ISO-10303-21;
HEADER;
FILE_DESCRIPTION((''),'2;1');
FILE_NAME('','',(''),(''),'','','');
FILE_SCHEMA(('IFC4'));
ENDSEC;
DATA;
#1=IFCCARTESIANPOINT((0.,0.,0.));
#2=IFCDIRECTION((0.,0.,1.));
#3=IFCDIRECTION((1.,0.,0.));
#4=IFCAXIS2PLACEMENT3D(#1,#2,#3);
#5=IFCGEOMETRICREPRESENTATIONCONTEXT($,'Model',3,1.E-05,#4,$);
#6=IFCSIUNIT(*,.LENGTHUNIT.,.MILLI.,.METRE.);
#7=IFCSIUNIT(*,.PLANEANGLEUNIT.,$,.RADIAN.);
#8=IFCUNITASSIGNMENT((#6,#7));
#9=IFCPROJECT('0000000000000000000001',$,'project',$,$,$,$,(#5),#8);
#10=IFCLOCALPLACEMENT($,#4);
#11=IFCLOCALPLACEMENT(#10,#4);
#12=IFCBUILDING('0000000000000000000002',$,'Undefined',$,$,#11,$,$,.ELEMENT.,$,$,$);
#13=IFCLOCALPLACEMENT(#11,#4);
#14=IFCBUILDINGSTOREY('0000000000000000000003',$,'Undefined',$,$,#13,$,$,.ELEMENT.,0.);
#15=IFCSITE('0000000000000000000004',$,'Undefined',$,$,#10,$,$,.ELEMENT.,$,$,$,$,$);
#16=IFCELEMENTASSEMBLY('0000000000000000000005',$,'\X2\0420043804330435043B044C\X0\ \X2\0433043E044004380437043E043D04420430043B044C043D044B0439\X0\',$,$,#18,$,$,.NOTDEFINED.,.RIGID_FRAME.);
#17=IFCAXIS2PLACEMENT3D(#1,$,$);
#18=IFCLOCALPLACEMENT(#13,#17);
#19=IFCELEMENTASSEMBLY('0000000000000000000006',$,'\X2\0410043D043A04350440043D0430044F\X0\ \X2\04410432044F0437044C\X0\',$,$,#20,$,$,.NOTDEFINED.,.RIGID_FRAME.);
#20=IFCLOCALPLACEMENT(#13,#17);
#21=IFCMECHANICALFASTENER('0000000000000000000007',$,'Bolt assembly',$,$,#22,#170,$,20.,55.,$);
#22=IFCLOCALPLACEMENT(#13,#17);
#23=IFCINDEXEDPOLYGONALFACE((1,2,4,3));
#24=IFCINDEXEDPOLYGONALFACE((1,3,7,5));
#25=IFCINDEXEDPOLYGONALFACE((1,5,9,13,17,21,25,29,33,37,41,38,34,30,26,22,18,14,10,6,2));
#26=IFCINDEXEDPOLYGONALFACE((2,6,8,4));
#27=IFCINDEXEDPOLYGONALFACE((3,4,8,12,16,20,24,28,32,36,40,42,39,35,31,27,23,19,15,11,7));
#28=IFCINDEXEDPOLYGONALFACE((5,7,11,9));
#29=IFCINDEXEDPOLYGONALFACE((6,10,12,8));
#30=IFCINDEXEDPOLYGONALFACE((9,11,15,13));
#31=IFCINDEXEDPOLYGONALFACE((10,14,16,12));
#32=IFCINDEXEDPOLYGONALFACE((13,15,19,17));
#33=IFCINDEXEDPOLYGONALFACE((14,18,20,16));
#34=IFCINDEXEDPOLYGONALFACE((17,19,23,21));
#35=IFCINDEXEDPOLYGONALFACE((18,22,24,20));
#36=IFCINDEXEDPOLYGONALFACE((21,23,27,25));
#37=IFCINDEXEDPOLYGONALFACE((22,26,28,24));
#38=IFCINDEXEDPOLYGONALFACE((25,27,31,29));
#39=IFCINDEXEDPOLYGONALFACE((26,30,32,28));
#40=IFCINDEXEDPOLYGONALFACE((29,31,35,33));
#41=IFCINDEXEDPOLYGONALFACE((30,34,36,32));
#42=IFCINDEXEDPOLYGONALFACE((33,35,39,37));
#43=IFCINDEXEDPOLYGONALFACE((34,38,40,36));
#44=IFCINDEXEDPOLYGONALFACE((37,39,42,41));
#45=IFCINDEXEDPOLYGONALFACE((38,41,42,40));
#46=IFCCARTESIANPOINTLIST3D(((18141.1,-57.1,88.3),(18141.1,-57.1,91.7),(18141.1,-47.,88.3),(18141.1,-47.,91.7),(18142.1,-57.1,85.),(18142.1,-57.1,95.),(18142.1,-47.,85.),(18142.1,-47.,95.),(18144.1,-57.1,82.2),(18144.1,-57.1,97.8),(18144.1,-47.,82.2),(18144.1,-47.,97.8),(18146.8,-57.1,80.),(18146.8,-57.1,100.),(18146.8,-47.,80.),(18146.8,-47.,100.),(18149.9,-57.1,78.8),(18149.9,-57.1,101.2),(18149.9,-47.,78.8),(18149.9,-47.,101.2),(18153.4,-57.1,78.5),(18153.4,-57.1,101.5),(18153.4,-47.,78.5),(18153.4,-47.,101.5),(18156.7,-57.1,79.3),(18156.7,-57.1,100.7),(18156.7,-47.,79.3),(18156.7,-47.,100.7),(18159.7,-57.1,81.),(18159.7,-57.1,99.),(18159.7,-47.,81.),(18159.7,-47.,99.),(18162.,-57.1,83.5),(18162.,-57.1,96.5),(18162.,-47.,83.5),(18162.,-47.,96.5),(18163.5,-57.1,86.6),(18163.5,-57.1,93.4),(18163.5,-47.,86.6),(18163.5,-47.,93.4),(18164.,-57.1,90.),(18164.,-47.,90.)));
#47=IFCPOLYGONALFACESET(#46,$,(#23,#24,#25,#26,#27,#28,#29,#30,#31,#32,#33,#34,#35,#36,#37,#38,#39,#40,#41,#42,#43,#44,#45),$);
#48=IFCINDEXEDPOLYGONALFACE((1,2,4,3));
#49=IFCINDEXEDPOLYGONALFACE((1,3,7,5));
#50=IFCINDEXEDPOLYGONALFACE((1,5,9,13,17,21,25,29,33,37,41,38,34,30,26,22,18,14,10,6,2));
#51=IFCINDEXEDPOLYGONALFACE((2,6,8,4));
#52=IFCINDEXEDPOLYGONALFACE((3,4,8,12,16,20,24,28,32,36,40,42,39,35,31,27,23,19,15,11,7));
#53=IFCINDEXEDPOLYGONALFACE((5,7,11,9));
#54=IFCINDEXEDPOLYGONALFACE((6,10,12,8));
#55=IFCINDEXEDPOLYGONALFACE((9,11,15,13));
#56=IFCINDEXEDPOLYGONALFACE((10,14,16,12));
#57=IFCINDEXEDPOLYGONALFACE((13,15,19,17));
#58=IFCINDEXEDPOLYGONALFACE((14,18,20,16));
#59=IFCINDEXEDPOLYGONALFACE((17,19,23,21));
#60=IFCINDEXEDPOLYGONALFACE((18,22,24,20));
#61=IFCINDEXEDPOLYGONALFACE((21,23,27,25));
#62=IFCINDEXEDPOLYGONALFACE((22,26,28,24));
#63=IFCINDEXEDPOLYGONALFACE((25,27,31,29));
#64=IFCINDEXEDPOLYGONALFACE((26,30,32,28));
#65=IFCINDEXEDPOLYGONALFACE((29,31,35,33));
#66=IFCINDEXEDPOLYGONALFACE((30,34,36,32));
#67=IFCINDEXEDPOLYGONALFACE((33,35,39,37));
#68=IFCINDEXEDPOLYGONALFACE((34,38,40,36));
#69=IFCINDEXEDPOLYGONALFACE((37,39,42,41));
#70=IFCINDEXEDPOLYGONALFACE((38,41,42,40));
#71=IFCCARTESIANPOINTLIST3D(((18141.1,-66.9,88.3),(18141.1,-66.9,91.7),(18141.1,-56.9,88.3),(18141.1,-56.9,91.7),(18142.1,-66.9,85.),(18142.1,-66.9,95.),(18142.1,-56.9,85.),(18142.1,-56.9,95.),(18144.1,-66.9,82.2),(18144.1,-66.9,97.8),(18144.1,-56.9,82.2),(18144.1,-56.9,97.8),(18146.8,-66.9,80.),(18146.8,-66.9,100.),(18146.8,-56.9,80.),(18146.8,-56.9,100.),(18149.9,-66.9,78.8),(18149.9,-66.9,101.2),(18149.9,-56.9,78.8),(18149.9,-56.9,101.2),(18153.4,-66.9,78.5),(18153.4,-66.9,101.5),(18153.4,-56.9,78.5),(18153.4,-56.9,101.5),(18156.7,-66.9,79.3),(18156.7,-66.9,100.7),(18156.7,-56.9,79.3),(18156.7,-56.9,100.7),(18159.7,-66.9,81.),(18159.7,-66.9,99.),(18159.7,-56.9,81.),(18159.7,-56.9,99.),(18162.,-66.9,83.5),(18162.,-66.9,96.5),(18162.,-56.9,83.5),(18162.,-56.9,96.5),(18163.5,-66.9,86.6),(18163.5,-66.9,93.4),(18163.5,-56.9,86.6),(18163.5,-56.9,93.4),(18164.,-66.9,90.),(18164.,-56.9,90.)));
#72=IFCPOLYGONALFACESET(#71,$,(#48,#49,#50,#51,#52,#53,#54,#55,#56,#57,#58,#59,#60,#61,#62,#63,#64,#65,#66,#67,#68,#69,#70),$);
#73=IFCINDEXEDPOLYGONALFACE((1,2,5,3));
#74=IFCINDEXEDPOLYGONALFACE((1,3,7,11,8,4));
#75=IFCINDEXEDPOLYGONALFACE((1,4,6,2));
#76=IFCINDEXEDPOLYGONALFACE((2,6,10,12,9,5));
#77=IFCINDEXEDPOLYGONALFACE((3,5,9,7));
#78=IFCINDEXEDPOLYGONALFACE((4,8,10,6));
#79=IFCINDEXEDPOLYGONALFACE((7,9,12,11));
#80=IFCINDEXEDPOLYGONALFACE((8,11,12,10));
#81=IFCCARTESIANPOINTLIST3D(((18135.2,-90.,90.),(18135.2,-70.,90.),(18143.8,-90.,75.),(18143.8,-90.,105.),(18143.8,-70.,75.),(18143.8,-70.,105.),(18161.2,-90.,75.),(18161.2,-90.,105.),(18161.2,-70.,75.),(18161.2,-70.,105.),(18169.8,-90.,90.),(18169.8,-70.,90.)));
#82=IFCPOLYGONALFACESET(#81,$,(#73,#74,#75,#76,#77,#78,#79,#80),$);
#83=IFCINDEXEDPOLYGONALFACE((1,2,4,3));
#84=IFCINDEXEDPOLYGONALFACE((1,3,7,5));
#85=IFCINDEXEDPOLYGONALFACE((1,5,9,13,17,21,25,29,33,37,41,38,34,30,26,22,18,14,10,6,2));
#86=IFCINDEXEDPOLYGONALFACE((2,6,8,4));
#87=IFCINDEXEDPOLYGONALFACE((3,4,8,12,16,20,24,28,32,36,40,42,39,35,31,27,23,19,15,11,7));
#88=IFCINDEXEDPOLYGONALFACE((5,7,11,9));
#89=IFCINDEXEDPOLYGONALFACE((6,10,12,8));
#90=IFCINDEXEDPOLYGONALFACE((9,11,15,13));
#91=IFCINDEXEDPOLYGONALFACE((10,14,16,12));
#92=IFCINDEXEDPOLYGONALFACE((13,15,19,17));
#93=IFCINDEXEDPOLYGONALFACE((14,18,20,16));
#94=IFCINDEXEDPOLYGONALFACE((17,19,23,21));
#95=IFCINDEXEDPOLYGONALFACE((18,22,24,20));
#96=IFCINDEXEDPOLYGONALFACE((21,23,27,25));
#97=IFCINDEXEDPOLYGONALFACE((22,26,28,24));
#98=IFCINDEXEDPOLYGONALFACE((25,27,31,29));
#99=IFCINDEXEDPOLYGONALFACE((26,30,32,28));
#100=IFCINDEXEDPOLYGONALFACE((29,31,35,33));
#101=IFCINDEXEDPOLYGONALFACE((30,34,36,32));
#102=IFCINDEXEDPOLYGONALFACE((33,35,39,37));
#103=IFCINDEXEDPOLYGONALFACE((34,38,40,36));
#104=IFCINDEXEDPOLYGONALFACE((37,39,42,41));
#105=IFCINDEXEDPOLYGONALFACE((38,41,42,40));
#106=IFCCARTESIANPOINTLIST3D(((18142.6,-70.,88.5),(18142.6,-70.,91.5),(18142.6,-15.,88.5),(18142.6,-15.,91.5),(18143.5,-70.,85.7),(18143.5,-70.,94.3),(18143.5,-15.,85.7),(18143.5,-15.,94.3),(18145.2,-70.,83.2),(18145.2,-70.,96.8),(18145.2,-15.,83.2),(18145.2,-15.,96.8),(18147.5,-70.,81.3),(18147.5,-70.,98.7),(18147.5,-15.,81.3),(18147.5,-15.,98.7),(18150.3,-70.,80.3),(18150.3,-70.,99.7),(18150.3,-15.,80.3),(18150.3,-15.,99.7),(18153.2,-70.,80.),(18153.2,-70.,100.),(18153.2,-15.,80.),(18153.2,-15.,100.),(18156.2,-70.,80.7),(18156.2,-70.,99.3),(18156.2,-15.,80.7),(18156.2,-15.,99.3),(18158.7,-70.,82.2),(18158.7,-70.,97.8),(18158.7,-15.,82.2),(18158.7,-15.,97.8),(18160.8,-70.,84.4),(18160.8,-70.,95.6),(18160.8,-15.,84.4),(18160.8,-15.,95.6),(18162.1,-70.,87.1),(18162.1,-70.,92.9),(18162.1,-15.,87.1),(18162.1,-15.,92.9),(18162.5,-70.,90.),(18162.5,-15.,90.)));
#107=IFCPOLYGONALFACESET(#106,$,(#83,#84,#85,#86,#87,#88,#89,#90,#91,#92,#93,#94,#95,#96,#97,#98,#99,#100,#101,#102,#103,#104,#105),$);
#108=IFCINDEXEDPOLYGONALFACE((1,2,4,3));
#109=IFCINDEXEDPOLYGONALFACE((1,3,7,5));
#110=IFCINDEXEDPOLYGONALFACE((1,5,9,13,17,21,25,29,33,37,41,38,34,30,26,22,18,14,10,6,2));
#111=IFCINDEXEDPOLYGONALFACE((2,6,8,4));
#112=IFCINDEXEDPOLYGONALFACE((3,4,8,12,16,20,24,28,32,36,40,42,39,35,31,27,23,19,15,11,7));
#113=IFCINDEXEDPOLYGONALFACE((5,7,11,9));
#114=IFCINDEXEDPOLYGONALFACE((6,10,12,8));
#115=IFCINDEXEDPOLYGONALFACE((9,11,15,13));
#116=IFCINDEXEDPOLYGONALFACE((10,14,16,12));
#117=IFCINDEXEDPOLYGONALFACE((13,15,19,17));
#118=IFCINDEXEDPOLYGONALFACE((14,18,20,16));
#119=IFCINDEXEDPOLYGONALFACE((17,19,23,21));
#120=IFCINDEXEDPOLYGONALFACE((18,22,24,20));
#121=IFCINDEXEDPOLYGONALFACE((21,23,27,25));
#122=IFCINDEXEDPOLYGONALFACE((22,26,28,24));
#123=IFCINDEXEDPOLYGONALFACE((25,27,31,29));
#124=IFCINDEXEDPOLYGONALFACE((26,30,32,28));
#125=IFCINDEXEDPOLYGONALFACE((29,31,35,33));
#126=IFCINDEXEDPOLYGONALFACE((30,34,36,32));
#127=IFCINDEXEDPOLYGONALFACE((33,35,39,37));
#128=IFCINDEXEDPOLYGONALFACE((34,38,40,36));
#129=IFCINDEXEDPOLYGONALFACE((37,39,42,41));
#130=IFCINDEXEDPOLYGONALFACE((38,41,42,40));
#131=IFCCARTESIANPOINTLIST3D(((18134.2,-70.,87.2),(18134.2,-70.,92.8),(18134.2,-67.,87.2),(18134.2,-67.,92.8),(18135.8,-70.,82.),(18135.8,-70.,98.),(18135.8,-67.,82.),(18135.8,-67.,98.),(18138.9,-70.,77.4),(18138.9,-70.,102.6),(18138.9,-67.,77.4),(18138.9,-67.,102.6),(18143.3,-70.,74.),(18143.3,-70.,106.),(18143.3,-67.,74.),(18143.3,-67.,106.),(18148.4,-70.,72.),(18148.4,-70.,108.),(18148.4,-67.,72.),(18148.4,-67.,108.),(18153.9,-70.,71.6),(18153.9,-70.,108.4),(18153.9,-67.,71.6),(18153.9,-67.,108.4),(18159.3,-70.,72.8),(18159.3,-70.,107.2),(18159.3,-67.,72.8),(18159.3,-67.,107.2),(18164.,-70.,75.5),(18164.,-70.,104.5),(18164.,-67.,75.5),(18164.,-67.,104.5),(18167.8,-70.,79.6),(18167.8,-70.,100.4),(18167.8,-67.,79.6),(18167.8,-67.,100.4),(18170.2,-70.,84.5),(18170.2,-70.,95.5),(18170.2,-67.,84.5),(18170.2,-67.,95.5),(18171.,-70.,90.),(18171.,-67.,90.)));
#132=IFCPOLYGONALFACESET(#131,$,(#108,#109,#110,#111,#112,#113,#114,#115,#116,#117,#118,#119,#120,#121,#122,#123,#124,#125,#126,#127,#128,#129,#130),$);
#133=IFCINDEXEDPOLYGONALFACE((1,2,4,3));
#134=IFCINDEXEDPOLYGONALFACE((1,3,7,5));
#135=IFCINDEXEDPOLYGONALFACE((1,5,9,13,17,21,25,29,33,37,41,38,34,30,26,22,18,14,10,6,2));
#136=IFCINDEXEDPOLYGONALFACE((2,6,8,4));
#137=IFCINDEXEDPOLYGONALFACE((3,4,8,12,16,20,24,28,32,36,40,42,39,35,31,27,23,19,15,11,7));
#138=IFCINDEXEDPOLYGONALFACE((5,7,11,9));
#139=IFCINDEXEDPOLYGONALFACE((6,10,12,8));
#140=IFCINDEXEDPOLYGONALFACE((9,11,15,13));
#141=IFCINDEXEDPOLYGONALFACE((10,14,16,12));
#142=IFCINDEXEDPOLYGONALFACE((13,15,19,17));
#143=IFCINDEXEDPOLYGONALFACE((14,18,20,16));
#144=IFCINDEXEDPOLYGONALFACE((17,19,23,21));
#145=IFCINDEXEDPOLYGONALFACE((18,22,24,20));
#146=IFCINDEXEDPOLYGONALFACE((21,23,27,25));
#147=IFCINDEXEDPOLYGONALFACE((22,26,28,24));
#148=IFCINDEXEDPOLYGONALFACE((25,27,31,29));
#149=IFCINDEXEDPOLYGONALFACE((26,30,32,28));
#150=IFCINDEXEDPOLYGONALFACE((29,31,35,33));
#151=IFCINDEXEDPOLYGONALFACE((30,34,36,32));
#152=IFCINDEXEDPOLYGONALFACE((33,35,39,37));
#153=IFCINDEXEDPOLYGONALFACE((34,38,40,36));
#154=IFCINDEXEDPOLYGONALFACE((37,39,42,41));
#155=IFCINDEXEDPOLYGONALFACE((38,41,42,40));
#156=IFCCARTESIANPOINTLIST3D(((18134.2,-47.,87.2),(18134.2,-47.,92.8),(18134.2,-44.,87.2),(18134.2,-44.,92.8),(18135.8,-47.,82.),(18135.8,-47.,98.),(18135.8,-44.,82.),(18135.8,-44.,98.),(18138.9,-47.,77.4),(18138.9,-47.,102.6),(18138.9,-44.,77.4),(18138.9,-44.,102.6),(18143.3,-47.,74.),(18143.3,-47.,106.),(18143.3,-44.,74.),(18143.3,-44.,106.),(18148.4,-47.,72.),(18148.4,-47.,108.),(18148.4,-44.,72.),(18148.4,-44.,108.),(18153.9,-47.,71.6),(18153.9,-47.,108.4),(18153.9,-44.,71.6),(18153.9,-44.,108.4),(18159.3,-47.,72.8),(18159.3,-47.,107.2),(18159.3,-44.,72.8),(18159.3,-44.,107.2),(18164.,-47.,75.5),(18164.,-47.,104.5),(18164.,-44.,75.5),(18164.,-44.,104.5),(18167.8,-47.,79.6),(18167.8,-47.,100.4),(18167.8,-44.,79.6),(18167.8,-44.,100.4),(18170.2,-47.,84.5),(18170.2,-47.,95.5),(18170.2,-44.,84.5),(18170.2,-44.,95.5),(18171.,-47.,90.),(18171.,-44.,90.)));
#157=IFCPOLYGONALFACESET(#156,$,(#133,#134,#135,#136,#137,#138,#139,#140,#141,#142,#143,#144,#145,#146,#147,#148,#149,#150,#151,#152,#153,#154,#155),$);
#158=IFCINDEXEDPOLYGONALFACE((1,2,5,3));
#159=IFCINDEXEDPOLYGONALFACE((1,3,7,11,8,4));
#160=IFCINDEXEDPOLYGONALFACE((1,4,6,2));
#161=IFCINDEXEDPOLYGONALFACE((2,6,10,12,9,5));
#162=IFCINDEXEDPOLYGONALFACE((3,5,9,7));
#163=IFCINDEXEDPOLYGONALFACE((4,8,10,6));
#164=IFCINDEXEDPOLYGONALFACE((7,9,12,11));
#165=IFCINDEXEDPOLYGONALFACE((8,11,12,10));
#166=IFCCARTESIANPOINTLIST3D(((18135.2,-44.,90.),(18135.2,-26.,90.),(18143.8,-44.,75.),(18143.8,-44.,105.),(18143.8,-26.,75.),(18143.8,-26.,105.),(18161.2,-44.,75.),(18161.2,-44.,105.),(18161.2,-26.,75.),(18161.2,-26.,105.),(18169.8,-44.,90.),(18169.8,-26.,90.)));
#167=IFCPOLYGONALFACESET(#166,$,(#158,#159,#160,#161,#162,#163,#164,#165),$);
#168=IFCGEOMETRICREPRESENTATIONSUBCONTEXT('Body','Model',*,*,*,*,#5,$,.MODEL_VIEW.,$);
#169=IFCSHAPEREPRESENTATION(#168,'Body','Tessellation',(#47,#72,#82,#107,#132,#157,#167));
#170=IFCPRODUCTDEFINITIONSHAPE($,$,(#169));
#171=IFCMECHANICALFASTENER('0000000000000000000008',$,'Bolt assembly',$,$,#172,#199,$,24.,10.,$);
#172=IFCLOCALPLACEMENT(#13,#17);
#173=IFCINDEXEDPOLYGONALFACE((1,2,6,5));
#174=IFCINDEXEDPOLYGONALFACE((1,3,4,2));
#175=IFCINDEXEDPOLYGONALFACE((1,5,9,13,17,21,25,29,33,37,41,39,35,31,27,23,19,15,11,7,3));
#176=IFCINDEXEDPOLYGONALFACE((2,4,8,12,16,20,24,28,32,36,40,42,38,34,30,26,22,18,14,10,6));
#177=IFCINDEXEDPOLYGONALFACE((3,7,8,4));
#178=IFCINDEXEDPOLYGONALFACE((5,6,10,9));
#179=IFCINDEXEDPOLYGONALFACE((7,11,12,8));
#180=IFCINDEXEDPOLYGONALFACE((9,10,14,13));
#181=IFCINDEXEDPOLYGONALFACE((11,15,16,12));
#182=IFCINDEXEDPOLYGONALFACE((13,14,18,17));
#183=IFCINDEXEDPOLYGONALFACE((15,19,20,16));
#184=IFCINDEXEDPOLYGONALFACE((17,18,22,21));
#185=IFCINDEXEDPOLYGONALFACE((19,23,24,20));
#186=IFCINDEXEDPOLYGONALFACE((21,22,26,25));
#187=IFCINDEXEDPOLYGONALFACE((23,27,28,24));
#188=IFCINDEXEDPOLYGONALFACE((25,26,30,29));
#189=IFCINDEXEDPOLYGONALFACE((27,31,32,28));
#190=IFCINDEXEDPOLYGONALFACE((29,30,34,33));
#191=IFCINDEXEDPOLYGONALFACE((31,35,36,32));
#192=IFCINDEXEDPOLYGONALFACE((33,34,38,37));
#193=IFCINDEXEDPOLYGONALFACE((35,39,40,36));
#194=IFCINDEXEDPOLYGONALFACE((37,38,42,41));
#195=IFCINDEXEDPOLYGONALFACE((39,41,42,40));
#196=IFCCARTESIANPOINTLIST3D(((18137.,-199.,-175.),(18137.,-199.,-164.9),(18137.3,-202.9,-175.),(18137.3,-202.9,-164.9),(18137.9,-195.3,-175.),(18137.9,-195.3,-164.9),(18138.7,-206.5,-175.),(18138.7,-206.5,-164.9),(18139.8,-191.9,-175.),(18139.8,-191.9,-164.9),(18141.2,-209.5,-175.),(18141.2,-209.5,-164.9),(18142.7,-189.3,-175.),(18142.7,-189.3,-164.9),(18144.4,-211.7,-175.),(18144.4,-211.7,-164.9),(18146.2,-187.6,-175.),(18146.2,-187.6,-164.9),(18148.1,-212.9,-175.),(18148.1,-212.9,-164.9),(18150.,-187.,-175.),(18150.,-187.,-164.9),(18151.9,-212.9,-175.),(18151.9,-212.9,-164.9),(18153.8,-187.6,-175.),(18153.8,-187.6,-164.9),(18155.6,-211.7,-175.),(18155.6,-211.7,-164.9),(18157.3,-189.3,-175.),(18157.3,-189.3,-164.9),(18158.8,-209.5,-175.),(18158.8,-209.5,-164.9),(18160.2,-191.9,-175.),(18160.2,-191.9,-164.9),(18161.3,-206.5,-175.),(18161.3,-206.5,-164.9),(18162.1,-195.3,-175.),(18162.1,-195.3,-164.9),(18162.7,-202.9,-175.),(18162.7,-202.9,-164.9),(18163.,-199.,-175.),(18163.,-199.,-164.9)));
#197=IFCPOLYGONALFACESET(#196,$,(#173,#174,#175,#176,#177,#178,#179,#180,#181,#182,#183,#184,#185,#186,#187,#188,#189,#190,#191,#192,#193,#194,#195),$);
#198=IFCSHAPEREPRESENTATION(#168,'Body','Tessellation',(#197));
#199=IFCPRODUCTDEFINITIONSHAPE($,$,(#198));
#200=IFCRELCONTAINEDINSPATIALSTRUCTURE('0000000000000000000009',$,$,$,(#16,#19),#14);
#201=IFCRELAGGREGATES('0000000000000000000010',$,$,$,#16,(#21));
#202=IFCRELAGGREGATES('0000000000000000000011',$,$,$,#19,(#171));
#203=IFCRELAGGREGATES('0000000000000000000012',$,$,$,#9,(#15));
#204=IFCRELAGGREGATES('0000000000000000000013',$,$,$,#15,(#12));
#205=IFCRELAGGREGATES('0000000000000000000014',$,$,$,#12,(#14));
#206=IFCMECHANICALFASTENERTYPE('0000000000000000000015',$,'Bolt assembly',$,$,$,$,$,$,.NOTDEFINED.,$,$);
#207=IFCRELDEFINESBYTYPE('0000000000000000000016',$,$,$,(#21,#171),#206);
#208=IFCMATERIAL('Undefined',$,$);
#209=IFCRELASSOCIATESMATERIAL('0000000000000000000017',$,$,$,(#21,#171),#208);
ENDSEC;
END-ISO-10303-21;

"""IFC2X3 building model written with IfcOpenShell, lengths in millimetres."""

from ifc_helpers import new_model, si_unit, frame, origin_with_axes, origin_2d_with_axis, place, context, subcontext, project, spatial, polyline, circle, outline, extrude, source, transform, mapped, material, type_object, element, aggregate, save


model = new_model("IFC2X3")

# Units and contexts
model_context = context("Model", 3, precision=1e-05, world=origin_with_axes())
body_context = subcontext(model_context, "Body", "Model", "MODEL_VIEW")
ifc_project = project(units=[si_unit("LENGTHUNIT", "METRE", prefix="MILLI"), si_unit("PLANEANGLEUNIT", "RADIAN")], contexts=[model_context])

# Site, building, storey
site_placement = place(None, origin_with_axes())
site = spatial("IfcSite", under=ifc_project, at=site_placement, Name="Undefined", CompositionType="ELEMENT")
building_placement = place(site_placement, origin_with_axes())
building = spatial("IfcBuilding", under=site, at=building_placement, Name="Undefined", CompositionType="ELEMENT")
storey_placement = place(building_placement, origin_with_axes())
storey = spatial("IfcBuildingStorey", under=building, at=storey_placement, Name="Undefined", CompositionType="ELEMENT", Elevation=0.0)

# Element assembly
assembly_1_placement = place(storey_placement, origin_with_axes())
assembly_1 = element("IfcElementAssembly", 1, at=assembly_1_placement, inside=storey, Name="Ригель горизонтальный", AssemblyPlace="NOTDEFINED", PredefinedType="RIGID_FRAME")

# Element assembly
assembly_2_placement = place(storey_placement, origin_with_axes())
assembly_2 = element("IfcElementAssembly", 2, at=assembly_2_placement, inside=storey, Name="Анкерная связь", AssemblyPlace="NOTDEFINED", PredefinedType="RIGID_FRAME")

# Mechanical fasteners
ifc_material_1 = material(Name="Undefined")
mechanical_fastener_type = type_object("IfcMechanicalFastenerType", Name="Bolt assembly")
shared_shape_1 = source(origin_with_axes(), body_context, "Body", "SweptSolid", [
    extrude(circle(Radius=11.5, at=origin_2d_with_axis()), frame((0.0, -0.1, 0.0), z_axis=(0.0, 1.0, 0.0), x_axis=(1.0, 0.0, 0.0)), (0.0, 0.0, 1.0), 10.1),
    extrude(circle(Radius=11.5, at=origin_2d_with_axis()), frame((0.0, -9.9, 0.0), z_axis=(0.0, 1.0, 0.0), x_axis=(1.0, 0.0, 0.0)), (0.0, 0.0, 1.0), 10.0),
    extrude(outline(polyline([(17.3, 0.0), (8.7, 15.0), (-8.7, 15.0), (-17.3, 0.0), (-8.7, -15.0), (8.7, -15.0), (17.3, 0.0)])), frame((0.0, -33.0, 0.0), z_axis=(0.0, 1.0, 0.0), x_axis=(1.0, 0.0, 0.0)), (0.0, 0.0, 1.0), 20.0),
    extrude(circle(Radius=10.0, at=origin_2d_with_axis()), frame((0.0, -13.0, 0.0), z_axis=(0.0, 1.0, 0.0), x_axis=(1.0, 0.0, 0.0)), (0.0, 0.0, 1.0), 55.0),
    extrude(circle(Radius=18.5, at=origin_2d_with_axis()), frame((0.0, -13.0, 0.0), z_axis=(0.0, 1.0, 0.0), x_axis=(1.0, 0.0, 0.0)), (0.0, 0.0, 1.0), 3.0),
    extrude(circle(Radius=18.5, at=origin_2d_with_axis()), frame((0.0, 10.0, 0.0), z_axis=(0.0, 1.0, 0.0), x_axis=(1.0, 0.0, 0.0)), (0.0, 0.0, 1.0), 3.0),
    extrude(outline(polyline([(17.3, 0.0), (8.7, 15.0), (-8.7, 15.0), (-17.3, 0.0), (-8.7, -15.0), (8.7, -15.0), (17.3, 0.0)])), frame((0.0, 13.0, 0.0), z_axis=(0.0, 1.0, 0.0), x_axis=(1.0, 0.0, 0.0)), (0.0, 0.0, 1.0), 18.0),
])
mechanical_fastener_1_placement = place(assembly_1_placement, frame((18152.5, -57.0, 90.0), z_axis=(0.0, 0.0, 1.0), x_axis=(1.0, 0.0, 0.0)))
mechanical_fastener_1 = element("IfcMechanicalFastener", 3, at=mechanical_fastener_1_placement, type_object=mechanical_fastener_type, material=ifc_material_1, Name="Bolt assembly", NominalDiameter=20.0, NominalLength=55.0, context=body_context, shape_type="MappedRepresentation", body=[
    mapped(shared_shape_1, transform((0.0, 0.0, 0.0))),
])
aggregate(assembly_1, [mechanical_fastener_1])
shared_shape_2 = source(origin_with_axes(), body_context, "Body", "SweptSolid", [
    extrude(circle(Radius=13.0, at=origin_2d_with_axis()), frame((0.0, 0.0, 0.0), z_axis=(0.0, 1.0, 0.0), x_axis=(1.0, 0.0, 0.0)), (0.0, 0.0, 1.0), 10.1),
])
mechanical_fastener_2_placement = place(assembly_2_placement, frame((18150.0, -200.0, -175.0), z_axis=(1.0, 0.0, 0.0), x_axis=(0.0, 1.0, 0.0)))
mechanical_fastener_2 = element("IfcMechanicalFastener", 4, at=mechanical_fastener_2_placement, type_object=mechanical_fastener_type, material=ifc_material_1, Name="Bolt assembly", NominalDiameter=24.0, NominalLength=10.0, context=body_context, shape_type="MappedRepresentation", body=[
    mapped(shared_shape_2, transform((0.0, 0.0, 0.0))),
])
aggregate(assembly_2, [mechanical_fastener_2])

save(model, "model.ifc")
